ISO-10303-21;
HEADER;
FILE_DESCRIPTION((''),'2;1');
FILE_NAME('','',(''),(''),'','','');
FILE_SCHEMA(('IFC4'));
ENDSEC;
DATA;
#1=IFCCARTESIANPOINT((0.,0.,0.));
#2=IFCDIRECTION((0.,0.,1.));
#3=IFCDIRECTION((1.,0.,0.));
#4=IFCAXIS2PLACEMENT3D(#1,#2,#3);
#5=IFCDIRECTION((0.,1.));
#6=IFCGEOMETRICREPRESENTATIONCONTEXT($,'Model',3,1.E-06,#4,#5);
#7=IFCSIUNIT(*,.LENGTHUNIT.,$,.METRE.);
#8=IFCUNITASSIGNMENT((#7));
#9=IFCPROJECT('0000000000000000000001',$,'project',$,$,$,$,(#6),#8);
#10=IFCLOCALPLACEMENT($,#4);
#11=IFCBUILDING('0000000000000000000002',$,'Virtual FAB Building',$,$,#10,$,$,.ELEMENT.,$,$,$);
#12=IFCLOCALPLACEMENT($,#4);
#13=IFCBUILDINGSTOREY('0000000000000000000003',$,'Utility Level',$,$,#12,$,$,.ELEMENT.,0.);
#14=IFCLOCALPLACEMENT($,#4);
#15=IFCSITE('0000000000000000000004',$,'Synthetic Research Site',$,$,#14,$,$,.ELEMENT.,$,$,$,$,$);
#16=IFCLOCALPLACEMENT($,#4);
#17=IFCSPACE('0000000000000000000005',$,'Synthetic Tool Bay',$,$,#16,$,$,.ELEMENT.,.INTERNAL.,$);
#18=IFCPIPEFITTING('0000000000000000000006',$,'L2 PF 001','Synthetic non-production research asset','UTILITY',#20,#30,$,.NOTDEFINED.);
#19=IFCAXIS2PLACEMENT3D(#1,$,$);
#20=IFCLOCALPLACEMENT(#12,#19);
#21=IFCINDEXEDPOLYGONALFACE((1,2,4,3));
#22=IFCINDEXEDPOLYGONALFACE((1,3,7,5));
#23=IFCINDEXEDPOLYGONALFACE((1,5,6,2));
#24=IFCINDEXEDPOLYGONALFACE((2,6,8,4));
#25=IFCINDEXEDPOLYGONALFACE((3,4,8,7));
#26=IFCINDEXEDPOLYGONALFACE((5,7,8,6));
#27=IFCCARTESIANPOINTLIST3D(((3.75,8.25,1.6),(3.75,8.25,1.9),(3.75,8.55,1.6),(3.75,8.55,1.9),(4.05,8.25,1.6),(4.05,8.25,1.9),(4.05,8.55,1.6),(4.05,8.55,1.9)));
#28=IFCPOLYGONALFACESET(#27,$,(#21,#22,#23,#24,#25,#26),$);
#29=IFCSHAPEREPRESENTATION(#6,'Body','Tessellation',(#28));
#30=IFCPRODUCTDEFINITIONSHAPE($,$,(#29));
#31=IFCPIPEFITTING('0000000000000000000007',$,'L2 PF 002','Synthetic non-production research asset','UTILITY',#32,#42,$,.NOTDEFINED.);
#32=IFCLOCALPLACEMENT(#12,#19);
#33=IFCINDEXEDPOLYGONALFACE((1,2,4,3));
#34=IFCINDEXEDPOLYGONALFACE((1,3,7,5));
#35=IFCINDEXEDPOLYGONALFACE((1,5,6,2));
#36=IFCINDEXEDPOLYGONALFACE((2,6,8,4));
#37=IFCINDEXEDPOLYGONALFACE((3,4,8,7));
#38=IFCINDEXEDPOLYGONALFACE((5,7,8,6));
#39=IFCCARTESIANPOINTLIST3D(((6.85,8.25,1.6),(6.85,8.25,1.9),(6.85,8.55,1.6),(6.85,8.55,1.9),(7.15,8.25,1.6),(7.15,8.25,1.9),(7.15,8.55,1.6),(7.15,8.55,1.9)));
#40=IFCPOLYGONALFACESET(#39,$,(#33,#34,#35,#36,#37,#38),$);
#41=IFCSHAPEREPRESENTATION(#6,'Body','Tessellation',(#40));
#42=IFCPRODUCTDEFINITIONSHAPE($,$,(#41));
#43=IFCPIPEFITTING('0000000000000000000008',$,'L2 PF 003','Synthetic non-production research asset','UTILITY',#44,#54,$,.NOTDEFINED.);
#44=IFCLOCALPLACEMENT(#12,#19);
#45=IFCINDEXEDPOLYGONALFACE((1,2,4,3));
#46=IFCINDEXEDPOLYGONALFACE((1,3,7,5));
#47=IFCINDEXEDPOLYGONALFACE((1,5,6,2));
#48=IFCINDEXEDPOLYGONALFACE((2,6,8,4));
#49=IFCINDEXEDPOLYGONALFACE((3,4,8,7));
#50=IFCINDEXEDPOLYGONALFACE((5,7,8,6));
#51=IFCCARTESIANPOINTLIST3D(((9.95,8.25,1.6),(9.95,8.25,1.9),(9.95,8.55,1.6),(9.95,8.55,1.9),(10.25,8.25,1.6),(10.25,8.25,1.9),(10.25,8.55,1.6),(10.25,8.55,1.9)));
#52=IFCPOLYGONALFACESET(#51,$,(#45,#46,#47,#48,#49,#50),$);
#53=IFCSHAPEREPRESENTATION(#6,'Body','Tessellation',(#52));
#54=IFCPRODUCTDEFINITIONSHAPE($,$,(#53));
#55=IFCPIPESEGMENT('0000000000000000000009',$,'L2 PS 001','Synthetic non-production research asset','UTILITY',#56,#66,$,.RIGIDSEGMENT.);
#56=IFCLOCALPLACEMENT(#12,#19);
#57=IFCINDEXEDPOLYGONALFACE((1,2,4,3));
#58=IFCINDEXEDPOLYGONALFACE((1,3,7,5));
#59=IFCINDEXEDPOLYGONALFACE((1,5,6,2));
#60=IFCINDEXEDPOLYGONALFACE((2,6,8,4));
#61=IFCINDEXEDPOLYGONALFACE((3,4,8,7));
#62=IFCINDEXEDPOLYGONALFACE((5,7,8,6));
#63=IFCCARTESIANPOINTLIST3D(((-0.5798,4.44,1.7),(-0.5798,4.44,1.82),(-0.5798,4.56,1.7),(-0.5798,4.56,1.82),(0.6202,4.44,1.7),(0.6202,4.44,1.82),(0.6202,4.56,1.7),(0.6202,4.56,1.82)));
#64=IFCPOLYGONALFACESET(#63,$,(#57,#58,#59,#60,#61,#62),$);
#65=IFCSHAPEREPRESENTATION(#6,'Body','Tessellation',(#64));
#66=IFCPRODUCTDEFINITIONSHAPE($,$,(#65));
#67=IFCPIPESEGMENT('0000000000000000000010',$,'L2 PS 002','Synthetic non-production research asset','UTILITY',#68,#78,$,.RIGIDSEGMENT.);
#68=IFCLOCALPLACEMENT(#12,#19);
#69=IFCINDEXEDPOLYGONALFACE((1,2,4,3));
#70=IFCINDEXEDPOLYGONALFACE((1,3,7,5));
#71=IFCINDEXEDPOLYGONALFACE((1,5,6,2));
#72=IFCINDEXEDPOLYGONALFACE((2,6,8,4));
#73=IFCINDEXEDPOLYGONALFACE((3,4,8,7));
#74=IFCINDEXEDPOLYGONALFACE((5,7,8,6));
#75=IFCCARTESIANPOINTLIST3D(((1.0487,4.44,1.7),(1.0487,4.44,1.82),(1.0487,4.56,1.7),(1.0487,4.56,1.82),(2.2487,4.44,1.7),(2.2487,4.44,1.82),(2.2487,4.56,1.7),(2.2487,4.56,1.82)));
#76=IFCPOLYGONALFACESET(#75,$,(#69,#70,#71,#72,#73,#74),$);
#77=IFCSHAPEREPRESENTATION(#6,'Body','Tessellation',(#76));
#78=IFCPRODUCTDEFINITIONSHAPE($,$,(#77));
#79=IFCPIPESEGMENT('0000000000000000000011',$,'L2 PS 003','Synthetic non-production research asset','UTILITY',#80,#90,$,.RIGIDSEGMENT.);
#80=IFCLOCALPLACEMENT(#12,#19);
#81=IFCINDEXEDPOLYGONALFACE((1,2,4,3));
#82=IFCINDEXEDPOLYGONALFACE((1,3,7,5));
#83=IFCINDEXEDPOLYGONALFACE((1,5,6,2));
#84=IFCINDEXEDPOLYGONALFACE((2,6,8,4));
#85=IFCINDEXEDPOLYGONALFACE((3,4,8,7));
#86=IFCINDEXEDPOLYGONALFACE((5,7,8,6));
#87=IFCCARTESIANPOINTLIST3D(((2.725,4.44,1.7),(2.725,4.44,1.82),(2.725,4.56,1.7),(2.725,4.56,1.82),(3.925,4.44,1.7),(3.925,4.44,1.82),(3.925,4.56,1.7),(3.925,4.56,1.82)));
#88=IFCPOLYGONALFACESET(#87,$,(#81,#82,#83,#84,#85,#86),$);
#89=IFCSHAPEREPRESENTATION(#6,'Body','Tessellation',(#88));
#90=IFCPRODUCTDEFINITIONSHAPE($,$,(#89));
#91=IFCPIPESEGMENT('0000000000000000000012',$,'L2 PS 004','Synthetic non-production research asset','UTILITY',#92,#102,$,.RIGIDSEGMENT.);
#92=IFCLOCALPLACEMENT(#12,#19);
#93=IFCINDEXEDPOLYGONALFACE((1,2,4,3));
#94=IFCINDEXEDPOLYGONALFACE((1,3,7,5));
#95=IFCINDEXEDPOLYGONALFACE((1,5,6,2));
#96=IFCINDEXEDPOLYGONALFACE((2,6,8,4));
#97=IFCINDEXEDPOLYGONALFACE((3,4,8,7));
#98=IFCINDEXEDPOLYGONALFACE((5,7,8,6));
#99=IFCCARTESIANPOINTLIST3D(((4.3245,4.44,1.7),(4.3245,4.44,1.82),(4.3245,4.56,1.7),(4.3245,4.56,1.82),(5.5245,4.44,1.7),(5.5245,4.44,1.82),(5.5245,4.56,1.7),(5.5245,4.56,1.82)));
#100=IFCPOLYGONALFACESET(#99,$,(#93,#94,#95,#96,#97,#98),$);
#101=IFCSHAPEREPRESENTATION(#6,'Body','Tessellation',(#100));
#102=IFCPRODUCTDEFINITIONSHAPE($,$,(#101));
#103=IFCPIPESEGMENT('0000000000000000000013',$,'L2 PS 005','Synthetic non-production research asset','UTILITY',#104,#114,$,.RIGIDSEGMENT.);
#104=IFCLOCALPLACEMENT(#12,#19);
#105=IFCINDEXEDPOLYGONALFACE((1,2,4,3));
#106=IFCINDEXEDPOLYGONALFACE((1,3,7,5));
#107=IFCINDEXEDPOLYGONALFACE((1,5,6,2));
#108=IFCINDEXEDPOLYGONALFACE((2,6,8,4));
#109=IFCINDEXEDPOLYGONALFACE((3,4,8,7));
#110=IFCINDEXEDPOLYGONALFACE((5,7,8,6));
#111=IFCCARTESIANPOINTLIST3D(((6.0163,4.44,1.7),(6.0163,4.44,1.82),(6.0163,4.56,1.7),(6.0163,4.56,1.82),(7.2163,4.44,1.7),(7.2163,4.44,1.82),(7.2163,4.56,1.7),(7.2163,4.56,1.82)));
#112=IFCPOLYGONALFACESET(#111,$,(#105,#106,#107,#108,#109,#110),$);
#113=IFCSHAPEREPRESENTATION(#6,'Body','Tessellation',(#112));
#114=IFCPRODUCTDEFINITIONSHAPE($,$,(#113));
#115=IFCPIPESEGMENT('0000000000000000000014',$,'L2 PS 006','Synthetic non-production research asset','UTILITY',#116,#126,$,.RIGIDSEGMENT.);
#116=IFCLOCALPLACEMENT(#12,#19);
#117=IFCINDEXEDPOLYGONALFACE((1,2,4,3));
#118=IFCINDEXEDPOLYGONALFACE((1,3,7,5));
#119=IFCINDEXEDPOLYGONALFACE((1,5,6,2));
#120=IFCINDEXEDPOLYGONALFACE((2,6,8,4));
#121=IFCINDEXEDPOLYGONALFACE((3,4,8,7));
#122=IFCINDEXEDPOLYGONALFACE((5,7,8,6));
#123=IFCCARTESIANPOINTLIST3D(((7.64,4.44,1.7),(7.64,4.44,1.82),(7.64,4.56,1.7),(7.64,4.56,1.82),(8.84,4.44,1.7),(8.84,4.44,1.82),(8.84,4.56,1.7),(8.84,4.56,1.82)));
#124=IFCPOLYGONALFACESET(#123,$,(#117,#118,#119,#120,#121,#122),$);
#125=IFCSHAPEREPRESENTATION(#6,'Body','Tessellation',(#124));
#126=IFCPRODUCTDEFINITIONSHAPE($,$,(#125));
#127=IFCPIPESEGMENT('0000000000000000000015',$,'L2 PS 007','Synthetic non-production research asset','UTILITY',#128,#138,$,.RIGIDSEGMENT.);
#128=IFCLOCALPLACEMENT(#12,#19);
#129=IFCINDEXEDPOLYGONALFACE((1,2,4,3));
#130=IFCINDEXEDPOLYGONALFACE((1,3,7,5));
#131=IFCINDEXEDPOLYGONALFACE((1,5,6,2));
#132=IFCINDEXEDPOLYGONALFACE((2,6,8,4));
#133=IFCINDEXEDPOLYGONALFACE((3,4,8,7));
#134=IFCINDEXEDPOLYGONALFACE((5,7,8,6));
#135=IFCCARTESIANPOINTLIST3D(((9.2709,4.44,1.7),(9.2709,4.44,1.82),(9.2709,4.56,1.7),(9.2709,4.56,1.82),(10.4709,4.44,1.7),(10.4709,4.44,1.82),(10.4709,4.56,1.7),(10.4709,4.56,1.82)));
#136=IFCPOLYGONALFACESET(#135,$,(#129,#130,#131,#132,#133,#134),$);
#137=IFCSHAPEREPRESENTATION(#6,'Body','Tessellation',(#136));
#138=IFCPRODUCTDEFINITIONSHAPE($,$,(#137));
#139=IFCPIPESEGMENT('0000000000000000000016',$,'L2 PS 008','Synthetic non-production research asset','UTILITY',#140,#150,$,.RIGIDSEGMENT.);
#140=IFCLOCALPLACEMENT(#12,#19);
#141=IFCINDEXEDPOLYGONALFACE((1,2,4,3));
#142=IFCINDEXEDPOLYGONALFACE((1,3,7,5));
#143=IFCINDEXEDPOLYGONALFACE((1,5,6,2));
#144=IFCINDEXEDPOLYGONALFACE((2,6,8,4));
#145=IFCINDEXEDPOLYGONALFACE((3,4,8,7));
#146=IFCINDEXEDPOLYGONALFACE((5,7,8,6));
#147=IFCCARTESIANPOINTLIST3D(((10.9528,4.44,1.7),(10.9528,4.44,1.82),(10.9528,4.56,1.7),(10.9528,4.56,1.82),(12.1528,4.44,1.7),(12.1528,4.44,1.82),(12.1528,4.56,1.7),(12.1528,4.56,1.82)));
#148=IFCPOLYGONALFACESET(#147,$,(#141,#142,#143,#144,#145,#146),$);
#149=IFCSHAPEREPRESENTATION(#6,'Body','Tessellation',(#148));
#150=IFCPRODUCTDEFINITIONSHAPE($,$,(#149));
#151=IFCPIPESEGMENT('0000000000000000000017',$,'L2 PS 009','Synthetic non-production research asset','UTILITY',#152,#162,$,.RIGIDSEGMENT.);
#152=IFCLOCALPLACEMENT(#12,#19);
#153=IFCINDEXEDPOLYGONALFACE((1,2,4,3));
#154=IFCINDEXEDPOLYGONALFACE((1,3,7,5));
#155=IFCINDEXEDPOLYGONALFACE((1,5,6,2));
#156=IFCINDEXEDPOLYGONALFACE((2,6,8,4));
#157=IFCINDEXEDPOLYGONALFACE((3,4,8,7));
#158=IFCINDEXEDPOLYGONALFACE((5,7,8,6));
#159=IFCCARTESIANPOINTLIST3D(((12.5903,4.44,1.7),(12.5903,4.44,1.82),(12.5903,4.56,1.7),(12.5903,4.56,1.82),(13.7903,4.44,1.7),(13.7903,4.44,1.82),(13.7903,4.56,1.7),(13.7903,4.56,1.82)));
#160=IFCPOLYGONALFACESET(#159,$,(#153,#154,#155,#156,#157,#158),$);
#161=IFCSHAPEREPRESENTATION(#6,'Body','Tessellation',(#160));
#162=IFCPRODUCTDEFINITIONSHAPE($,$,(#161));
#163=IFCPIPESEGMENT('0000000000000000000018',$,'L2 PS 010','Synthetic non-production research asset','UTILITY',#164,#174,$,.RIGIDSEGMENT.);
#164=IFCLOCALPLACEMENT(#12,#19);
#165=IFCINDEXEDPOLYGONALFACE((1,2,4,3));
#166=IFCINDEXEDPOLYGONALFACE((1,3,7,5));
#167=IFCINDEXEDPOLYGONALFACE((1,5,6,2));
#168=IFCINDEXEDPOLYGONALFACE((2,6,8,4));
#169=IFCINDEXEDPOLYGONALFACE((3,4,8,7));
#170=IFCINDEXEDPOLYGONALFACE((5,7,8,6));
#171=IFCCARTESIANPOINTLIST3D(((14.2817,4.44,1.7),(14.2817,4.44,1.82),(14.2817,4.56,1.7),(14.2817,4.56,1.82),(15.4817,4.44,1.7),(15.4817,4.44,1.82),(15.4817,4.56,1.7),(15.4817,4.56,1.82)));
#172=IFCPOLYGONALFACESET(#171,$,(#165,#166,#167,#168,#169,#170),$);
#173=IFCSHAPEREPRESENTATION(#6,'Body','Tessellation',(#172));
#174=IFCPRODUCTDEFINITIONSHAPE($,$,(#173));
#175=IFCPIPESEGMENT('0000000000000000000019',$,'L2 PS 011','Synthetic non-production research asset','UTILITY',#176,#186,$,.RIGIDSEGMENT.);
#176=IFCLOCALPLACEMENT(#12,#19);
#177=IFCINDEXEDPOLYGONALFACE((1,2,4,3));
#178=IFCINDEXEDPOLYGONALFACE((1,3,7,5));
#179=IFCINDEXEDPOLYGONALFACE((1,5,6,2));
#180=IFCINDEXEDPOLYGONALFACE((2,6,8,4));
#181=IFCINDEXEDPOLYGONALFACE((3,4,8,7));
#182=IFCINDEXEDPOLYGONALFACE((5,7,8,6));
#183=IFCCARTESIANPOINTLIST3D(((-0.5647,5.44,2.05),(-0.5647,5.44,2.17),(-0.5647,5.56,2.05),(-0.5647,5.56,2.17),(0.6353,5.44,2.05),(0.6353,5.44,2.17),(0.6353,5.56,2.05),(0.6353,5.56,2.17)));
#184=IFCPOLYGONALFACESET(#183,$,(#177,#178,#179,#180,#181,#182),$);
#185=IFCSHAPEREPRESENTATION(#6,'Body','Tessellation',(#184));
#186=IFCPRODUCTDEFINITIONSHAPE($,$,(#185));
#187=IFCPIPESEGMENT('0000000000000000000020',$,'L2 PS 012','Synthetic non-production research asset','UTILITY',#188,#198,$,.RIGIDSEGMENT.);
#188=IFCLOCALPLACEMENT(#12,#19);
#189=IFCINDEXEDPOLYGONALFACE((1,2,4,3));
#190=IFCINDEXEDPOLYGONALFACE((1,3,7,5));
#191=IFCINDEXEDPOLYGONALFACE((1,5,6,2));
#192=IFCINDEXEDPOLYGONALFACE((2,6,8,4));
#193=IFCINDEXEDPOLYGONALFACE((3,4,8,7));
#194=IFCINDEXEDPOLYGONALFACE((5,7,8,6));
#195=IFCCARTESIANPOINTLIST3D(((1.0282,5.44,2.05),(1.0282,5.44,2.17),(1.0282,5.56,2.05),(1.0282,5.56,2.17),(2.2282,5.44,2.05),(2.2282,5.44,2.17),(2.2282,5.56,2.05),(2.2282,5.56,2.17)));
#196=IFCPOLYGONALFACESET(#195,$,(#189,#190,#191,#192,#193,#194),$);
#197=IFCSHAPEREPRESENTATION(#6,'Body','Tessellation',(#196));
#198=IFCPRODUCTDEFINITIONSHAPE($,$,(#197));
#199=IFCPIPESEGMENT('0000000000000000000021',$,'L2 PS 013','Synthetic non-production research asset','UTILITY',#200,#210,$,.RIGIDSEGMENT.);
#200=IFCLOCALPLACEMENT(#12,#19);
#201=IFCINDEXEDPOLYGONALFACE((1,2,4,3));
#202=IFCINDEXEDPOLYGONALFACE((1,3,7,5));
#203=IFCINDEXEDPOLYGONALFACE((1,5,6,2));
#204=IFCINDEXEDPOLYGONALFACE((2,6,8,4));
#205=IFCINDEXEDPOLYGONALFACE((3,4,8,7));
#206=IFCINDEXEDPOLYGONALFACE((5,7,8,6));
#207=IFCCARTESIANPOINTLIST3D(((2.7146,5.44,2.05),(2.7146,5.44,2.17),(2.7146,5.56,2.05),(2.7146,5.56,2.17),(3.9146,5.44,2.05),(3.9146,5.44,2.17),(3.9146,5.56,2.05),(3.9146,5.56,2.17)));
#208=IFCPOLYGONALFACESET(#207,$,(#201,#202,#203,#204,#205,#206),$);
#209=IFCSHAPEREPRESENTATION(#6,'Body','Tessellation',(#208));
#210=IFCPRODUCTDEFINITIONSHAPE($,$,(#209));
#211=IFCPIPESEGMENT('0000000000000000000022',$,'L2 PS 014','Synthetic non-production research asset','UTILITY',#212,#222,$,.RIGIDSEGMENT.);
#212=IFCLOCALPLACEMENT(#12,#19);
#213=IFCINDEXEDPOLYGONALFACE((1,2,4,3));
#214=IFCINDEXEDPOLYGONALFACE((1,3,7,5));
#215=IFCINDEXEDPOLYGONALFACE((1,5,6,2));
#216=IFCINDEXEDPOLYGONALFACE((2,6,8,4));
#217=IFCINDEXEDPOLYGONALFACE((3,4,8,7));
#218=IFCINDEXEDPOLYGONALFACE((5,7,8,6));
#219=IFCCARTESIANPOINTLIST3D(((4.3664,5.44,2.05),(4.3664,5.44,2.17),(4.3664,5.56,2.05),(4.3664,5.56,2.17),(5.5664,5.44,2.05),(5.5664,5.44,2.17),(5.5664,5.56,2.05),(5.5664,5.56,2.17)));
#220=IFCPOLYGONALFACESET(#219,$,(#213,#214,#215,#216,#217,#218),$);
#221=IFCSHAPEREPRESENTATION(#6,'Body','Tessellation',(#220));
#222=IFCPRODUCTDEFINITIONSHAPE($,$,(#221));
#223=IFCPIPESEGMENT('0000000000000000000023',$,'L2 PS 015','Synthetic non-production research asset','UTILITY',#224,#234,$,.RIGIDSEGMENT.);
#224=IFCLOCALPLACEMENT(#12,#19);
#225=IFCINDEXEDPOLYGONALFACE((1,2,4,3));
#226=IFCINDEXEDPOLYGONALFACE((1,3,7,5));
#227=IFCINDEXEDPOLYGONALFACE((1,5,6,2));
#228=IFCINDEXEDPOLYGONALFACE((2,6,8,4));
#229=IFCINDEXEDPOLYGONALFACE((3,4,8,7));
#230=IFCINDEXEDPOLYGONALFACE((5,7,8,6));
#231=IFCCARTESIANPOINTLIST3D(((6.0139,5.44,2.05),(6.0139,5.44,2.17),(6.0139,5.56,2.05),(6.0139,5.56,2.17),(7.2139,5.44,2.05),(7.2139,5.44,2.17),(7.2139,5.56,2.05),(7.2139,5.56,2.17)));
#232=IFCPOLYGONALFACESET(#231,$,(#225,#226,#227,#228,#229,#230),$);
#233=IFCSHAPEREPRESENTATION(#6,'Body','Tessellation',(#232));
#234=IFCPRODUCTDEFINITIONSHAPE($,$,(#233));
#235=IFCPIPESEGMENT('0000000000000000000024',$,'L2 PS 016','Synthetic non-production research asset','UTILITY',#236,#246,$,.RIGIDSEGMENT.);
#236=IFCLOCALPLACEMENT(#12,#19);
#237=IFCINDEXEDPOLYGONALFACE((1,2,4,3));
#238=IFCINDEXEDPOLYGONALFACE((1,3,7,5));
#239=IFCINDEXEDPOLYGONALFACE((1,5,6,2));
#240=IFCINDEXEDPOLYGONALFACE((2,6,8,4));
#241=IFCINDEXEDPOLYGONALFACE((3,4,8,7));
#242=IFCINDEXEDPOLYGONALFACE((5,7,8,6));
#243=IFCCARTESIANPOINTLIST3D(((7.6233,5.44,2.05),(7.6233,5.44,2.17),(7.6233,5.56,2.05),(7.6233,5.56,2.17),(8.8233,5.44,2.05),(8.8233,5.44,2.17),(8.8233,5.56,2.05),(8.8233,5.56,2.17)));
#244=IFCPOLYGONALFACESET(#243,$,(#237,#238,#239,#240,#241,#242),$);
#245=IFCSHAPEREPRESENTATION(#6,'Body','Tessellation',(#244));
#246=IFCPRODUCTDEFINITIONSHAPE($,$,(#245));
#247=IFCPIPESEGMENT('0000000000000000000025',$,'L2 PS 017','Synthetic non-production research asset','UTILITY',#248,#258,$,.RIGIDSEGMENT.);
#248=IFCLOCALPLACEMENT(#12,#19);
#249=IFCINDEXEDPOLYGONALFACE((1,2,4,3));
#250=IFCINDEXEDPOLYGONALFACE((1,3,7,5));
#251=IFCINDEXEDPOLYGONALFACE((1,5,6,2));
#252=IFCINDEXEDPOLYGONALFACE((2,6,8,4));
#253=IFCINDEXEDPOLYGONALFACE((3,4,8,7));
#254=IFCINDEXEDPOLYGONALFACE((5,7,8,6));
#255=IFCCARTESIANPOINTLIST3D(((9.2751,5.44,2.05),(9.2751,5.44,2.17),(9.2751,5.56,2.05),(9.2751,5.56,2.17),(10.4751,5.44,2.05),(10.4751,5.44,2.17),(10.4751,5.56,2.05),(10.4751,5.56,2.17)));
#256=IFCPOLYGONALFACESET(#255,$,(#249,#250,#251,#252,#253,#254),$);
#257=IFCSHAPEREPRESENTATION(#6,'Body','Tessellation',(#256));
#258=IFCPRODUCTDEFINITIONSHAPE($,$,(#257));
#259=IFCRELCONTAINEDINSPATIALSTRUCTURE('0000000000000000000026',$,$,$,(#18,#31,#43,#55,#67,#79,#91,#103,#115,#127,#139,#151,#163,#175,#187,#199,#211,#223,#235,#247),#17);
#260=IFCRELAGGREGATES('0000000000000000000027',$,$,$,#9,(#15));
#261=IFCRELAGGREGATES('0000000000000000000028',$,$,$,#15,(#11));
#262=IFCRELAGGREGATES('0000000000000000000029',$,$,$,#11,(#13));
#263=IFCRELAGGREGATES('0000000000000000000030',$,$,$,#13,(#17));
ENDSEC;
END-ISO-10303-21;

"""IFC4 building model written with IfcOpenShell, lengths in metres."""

from ifc_helpers import new_model, si_unit, direction, frame, origin_with_axes, origin_2d_with_axis, place, context, project, spatial, rectangle, extrude, element, save


model = new_model("IFC4")

# Units and contexts
model_context = context("Model", 3, precision=1e-06, world=origin_with_axes(), true_north=direction((0.0, 1.0)))
ifc_project = project(units=[si_unit("LENGTHUNIT", "METRE")], contexts=[model_context])

# Site, building, storey, space
site_placement = place(None, origin_with_axes())
site = spatial("IfcSite", under=ifc_project, at=site_placement, Name="Synthetic Research Site", CompositionType="ELEMENT")
building_placement = place(None, origin_with_axes())
building = spatial("IfcBuilding", under=site, at=building_placement, Name="Virtual FAB Building", CompositionType="ELEMENT")
storey_placement = place(None, origin_with_axes())
storey = spatial("IfcBuildingStorey", under=building, at=storey_placement, Name="Utility Level", CompositionType="ELEMENT", Elevation=0.0)
space_placement = place(None, origin_with_axes())
space = spatial("IfcSpace", under=storey, at=space_placement, Name="Synthetic Tool Bay", CompositionType="ELEMENT", PredefinedType="INTERNAL")

# Pipe fittings
for number, where, z_axis, x_axis, name in (
    (1, (3.9, 8.4, 1.6), (0.0, 0.0, 1.0), (1.0, 0.0, 0.0), "L2 PF 001"),
    (2, (7.0, 8.4, 1.6), (0.0, 0.0, 1.0), (1.0, 0.0, 0.0), "L2 PF 002"),
    (3, (10.1, 8.4, 1.6), (0.0, 0.0, 1.0), (1.0, 0.0, 0.0), "L2 PF 003"),
):
    element("IfcPipeFitting", number, at=place(None, frame(where, z_axis=z_axis, x_axis=x_axis)), inside=space, Name=name, Description="Synthetic non-production research asset", ObjectType="UTILITY", PredefinedType="NOTDEFINED", context=model_context, shape_type="SweptSolid", body=[
        extrude(rectangle(XDim=0.3, YDim=0.3, at=origin_2d_with_axis()), origin_with_axes(), (0.0, 0.0, 1.0), 0.3),
    ])

# Pipe segments
for number, where, z_axis, x_axis, name in (
    (4, (0.0202, 4.5, 1.7), (0.0, 0.0, 1.0), (1.0, 0.0, 0.0), "L2 PS 001"),
    (5, (1.6487, 4.5, 1.7), (0.0, 0.0, 1.0), (1.0, 0.0, 0.0), "L2 PS 002"),
    (6, (3.325, 4.5, 1.7), (0.0, 0.0, 1.0), (1.0, 0.0, 0.0), "L2 PS 003"),
    (7, (4.9245, 4.5, 1.7), (0.0, 0.0, 1.0), (1.0, 0.0, 0.0), "L2 PS 004"),
    (8, (6.6163, 4.5, 1.7), (0.0, 0.0, 1.0), (1.0, 0.0, 0.0), "L2 PS 005"),
    (9, (8.24, 4.5, 1.7), (0.0, 0.0, 1.0), (1.0, 0.0, 0.0), "L2 PS 006"),
    (10, (9.8709, 4.5, 1.7), (0.0, 0.0, 1.0), (1.0, 0.0, 0.0), "L2 PS 007"),
    (11, (11.5528, 4.5, 1.7), (0.0, 0.0, 1.0), (1.0, 0.0, 0.0), "L2 PS 008"),
    (12, (13.1903, 4.5, 1.7), (0.0, 0.0, 1.0), (1.0, 0.0, 0.0), "L2 PS 009"),
    (13, (14.8817, 4.5, 1.7), (0.0, 0.0, 1.0), (1.0, 0.0, 0.0), "L2 PS 010"),
    (14, (0.0353, 5.5, 2.05), (0.0, 0.0, 1.0), (1.0, 0.0, 0.0), "L2 PS 011"),
    (15, (1.6282, 5.5, 2.05), (0.0, 0.0, 1.0), (1.0, 0.0, 0.0), "L2 PS 012"),
    (16, (3.3146, 5.5, 2.05), (0.0, 0.0, 1.0), (1.0, 0.0, 0.0), "L2 PS 013"),
    (17, (4.9664, 5.5, 2.05), (0.0, 0.0, 1.0), (1.0, 0.0, 0.0), "L2 PS 014"),
    (18, (6.6139, 5.5, 2.05), (0.0, 0.0, 1.0), (1.0, 0.0, 0.0), "L2 PS 015"),
    (19, (8.2233, 5.5, 2.05), (0.0, 0.0, 1.0), (1.0, 0.0, 0.0), "L2 PS 016"),
    (20, (9.8751, 5.5, 2.05), (0.0, 0.0, 1.0), (1.0, 0.0, 0.0), "L2 PS 017"),
):
    element("IfcPipeSegment", number, at=place(None, frame(where, z_axis=z_axis, x_axis=x_axis)), inside=space, Name=name, Description="Synthetic non-production research asset", ObjectType="UTILITY", PredefinedType="RIGIDSEGMENT", context=model_context, shape_type="SweptSolid", body=[
        extrude(rectangle(XDim=1.2, YDim=0.12, at=origin_2d_with_axis()), origin_with_axes(), (0.0, 0.0, 1.0), 0.12),
    ])

save(model, "model.ifc")
